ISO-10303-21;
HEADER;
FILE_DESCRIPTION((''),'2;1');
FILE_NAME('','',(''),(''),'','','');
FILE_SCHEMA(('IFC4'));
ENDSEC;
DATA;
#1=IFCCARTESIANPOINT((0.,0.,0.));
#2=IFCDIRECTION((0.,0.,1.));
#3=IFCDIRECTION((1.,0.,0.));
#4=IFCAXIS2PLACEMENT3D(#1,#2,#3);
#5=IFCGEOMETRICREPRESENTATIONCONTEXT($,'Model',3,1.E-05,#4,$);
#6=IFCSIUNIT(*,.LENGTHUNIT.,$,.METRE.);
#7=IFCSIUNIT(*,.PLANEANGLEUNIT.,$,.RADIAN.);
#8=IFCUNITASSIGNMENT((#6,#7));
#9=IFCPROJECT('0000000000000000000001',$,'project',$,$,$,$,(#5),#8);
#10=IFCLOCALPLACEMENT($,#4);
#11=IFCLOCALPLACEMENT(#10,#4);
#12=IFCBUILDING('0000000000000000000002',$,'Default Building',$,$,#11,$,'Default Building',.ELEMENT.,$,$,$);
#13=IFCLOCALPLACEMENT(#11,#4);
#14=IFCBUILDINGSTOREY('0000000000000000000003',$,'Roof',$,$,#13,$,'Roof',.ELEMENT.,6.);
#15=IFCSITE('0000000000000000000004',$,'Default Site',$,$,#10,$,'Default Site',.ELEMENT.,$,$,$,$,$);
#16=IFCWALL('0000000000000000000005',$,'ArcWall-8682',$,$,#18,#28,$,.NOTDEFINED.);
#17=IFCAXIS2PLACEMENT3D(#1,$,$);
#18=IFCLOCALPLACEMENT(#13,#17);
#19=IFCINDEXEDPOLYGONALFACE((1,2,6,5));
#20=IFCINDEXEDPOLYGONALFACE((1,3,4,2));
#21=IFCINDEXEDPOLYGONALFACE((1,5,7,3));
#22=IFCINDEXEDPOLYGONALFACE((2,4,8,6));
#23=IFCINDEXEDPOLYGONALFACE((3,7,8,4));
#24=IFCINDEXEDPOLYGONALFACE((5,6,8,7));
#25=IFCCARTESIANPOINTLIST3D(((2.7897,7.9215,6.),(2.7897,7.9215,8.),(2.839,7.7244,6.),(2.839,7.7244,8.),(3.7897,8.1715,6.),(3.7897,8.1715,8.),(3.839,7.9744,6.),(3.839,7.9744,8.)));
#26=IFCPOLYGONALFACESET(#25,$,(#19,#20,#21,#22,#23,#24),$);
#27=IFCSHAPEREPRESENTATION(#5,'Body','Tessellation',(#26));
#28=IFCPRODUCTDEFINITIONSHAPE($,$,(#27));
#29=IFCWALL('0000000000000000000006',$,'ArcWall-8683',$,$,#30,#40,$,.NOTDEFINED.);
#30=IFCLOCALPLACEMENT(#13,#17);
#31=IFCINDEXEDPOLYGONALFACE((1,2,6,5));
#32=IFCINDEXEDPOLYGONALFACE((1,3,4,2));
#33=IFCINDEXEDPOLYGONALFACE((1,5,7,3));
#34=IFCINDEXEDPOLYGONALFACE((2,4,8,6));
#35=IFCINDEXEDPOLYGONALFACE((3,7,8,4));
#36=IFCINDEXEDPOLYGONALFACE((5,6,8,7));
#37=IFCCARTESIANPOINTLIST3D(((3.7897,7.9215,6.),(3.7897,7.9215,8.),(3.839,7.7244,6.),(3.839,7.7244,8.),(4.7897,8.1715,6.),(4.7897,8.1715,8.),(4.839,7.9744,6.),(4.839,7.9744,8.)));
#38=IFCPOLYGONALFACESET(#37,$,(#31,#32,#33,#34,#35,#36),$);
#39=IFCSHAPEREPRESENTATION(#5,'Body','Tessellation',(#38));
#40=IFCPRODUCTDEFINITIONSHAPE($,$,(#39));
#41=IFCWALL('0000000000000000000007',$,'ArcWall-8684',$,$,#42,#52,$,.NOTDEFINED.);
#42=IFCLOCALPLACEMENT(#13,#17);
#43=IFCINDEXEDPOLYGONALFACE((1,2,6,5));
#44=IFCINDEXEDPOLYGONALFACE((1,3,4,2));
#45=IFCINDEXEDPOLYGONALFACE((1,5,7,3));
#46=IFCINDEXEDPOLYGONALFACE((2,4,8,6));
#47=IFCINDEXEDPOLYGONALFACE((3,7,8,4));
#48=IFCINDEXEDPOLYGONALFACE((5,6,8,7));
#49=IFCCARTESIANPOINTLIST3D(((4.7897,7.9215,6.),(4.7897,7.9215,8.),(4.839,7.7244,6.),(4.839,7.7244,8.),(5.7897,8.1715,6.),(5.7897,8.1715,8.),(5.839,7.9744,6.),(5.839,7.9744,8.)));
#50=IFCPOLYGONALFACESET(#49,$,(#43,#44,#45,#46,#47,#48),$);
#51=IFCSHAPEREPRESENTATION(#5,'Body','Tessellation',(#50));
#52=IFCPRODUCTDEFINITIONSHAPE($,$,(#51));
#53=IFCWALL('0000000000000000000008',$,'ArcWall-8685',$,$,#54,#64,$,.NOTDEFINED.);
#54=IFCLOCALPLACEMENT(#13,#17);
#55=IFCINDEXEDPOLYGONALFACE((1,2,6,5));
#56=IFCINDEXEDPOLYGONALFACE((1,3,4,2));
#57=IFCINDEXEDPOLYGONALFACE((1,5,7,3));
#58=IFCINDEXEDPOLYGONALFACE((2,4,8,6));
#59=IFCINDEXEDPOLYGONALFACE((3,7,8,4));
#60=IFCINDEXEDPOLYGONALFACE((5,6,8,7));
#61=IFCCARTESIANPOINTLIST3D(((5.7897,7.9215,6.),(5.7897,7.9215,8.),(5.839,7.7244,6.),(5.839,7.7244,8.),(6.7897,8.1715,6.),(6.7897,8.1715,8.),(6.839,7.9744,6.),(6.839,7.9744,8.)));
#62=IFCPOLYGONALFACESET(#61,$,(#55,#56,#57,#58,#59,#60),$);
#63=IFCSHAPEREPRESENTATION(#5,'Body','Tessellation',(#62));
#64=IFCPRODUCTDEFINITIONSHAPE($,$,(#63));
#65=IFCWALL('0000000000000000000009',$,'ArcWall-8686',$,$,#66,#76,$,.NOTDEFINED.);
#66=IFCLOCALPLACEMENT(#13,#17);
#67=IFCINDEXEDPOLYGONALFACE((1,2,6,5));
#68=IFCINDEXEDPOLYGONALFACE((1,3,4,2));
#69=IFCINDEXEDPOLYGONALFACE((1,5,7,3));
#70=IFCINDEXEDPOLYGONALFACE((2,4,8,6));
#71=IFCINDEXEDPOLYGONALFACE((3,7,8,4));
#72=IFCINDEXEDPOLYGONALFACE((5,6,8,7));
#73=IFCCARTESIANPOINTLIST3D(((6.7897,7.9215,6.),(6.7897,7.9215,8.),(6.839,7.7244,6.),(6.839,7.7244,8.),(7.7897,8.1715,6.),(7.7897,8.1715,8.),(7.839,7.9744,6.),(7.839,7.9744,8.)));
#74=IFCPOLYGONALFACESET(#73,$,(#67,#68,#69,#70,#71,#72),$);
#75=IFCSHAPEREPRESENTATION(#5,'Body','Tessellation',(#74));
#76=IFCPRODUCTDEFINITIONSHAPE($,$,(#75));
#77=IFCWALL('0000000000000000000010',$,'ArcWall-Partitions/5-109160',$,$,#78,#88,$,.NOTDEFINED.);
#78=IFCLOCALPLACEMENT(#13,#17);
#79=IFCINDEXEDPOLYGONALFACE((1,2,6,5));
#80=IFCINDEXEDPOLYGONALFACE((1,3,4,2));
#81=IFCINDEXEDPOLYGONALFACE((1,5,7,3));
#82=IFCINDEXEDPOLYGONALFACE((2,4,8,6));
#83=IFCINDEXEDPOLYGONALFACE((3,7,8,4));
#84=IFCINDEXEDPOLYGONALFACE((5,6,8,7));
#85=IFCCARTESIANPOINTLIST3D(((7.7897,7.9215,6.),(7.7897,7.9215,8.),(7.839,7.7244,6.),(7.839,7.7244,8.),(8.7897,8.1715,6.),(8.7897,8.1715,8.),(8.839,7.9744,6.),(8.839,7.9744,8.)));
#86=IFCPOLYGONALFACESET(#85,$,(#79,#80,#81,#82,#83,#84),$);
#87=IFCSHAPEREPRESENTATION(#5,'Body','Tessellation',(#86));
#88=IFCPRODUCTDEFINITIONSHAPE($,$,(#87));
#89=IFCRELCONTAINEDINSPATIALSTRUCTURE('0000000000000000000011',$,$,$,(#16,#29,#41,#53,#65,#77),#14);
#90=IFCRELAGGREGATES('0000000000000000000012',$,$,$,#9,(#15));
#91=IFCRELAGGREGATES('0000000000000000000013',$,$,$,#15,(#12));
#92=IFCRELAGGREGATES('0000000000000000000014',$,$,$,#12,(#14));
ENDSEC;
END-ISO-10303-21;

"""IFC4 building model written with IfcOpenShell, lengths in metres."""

from ifc_helpers import new_model, si_unit, frame, origin_with_axes, origin_2d_with_axis, place, context, project, spatial, rectangle, extrude, element, save


model = new_model("IFC4")

# Units and contexts
model_context = context("Model", 3, precision=1e-05, world=origin_with_axes())
ifc_project = project(units=[si_unit("LENGTHUNIT", "METRE"), si_unit("PLANEANGLEUNIT", "RADIAN")], contexts=[model_context])

# Site, building, storey
site_placement = place(None, origin_with_axes())
site = spatial("IfcSite", under=ifc_project, at=site_placement, Name="Default Site", LongName="Default Site", CompositionType="ELEMENT")
building_placement = place(site_placement, origin_with_axes())
building = spatial("IfcBuilding", under=site, at=building_placement, Name="Default Building", LongName="Default Building", CompositionType="ELEMENT")
storey_placement = place(building_placement, origin_with_axes())
storey = spatial("IfcBuildingStorey", under=building, at=storey_placement, Name="Roof", LongName="Roof", CompositionType="ELEMENT", Elevation=6.0)

# Walls
for number, where, z_axis, x_axis, name in (
    (1, (3.3144, 7.948, 6.0), (0.0, 0.0, 1.0), (0.970143, 0.242536, 0.0), "ArcWall-8682"),
    (2, (4.3144, 7.948, 6.0), (0.0, 0.0, 1.0), (0.970143, 0.242536, 0.0), "ArcWall-8683"),
    (3, (5.3144, 7.948, 6.0), (0.0, 0.0, 1.0), (0.970143, 0.242536, 0.0), "ArcWall-8684"),
    (4, (6.3144, 7.948, 6.0), (0.0, 0.0, 1.0), (0.970143, 0.242536, 0.0), "ArcWall-8685"),
    (5, (7.3144, 7.948, 6.0), (0.0, 0.0, 1.0), (0.970143, 0.242536, 0.0), "ArcWall-8686"),
    (6, (8.3144, 7.948, 6.0), (0.0, 0.0, 1.0), (0.970143, 0.242536, 0.0), "ArcWall-Partitions/5-109160"),
):
    element("IfcWall", number, at=place(storey_placement, frame(where, z_axis=z_axis, x_axis=x_axis)), inside=storey, Name=name, PredefinedType="NOTDEFINED", context=model_context, shape_type="SweptSolid", body=[
        extrude(rectangle(XDim=1.0308, YDim=0.2032, at=origin_2d_with_axis()), origin_with_axes(), (0.0, 0.0, 1.0), 2.0),
    ])

save(model, "model.ifc")
